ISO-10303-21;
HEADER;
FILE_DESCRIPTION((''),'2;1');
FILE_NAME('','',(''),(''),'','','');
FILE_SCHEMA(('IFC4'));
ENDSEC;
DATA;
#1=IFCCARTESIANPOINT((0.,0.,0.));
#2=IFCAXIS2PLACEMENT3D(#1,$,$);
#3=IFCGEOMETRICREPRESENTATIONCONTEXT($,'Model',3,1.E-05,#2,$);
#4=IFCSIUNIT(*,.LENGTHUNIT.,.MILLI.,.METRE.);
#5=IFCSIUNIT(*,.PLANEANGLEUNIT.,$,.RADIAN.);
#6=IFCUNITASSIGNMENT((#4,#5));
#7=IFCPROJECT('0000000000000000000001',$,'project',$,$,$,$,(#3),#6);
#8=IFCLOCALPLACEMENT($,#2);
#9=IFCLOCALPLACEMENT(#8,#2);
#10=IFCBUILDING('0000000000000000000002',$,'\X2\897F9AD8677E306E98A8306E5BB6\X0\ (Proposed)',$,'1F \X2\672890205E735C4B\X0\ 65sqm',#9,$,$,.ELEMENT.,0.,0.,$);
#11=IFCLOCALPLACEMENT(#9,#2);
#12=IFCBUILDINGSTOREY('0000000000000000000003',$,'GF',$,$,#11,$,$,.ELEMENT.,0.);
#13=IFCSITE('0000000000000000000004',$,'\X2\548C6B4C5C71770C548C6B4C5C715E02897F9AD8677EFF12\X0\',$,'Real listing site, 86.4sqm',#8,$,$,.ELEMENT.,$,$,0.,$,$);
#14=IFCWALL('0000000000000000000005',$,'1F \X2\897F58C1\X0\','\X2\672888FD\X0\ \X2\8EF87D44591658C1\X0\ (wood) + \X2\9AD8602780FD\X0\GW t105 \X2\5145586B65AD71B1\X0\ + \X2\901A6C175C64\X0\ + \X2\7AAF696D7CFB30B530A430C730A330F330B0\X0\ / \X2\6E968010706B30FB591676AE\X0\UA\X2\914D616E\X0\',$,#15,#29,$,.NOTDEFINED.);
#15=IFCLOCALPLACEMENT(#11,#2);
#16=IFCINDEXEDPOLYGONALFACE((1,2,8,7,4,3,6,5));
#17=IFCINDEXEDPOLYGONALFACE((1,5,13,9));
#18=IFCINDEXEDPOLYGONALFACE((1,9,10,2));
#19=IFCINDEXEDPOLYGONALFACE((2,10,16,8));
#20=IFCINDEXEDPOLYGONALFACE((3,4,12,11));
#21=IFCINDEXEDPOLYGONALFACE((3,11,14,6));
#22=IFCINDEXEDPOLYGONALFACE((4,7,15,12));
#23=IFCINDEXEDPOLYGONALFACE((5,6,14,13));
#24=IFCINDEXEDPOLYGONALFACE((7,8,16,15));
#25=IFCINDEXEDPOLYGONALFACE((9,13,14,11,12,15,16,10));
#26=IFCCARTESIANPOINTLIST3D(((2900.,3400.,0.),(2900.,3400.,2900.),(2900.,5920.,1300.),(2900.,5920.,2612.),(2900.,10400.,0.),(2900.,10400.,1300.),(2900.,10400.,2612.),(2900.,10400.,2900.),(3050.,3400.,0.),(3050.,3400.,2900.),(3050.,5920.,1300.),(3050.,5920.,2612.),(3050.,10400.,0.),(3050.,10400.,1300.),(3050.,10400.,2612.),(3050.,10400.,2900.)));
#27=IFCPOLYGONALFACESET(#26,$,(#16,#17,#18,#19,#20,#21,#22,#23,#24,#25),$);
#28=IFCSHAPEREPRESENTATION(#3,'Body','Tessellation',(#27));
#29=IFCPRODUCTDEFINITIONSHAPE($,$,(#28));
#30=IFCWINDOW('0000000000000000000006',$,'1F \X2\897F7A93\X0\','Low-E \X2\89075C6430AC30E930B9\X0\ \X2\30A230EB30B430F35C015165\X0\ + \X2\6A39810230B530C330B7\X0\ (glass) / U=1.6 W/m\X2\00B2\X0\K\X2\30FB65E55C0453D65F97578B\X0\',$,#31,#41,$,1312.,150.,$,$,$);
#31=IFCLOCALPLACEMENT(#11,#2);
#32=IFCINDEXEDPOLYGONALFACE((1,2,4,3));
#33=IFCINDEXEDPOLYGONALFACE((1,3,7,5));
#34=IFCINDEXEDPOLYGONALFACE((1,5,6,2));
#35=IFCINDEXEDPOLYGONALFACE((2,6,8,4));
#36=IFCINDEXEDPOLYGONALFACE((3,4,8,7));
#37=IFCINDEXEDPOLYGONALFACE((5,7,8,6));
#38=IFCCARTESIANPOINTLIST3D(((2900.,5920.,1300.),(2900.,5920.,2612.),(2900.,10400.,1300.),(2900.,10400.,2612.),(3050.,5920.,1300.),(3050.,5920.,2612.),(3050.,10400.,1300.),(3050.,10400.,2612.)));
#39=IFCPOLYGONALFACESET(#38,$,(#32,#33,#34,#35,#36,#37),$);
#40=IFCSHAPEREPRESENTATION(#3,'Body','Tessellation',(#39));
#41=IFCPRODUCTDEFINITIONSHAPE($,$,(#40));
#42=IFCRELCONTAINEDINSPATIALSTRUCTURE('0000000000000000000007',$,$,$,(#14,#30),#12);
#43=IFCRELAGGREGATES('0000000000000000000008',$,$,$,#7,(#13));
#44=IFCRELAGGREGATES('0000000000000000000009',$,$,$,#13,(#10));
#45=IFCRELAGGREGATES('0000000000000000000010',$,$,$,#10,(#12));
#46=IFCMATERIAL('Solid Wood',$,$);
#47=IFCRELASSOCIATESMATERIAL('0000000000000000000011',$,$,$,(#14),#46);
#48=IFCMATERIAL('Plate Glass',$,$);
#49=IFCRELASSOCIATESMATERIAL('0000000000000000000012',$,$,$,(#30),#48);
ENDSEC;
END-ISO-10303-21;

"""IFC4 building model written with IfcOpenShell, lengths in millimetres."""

from ifc_helpers import new_model, si_unit, frame, frame_2d, origin, place, context, project, spatial, rectangle, extrude, material, element, fill, save


model = new_model("IFC4")

# Units and contexts
model_context = context("Model", 3, precision=1e-05, world=origin())
ifc_project = project(units=[si_unit("LENGTHUNIT", "METRE", prefix="MILLI"), si_unit("PLANEANGLEUNIT", "RADIAN")], contexts=[model_context])

# Site, building, storey
site_placement = place(None, origin())
site = spatial("IfcSite", under=ifc_project, at=site_placement, Name="和歌山県和歌山市西高松２", ObjectType="Real listing site, 86.4sqm", CompositionType="ELEMENT", RefElevation=0.0)
building_placement = place(site_placement, origin())
building = spatial("IfcBuilding", under=site, at=building_placement, Name="西高松の風の家 (Proposed)", ObjectType="1F 木造平屋 65sqm", CompositionType="ELEMENT", ElevationOfRefHeight=0.0, ElevationOfTerrain=0.0)
storey_placement = place(building_placement, origin())
storey = spatial("IfcBuildingStorey", under=building, at=storey_placement, Name="GF", CompositionType="ELEMENT", Elevation=0.0)

# Shared definitions
ifc_material_1 = material(Name="Solid Wood")

# Shared definitions
ifc_material_2 = material(Name="Plate Glass")

# Wall, opening, window
wall_1_placement = place(storey_placement, frame((1450.0, 1700.0, 0.0)))
wall_1 = element("IfcWall", 1, at=wall_1_placement, inside=storey, material=ifc_material_1, Name="1F 西壁", Description="木製 軸組外壁 (wood) + 高性能GW t105 充填断熱 + 通気層 + 窯業系サイディング / 準耐火・外皮UA配慮", PredefinedType="NOTDEFINED", context=model_context, shape_type="SweptSolid", body=[
    extrude(rectangle(XDim=150.0, YDim=7000.0, at=frame_2d((75.0, 3500.0))), frame((1450.0, 1700.0, 0.0)), (0.0, 0.0, 1.0), 2900.0),
])
opening_1_placement = place(storey_placement, frame((1450.0, 2960.0, 650.0)))
opening_1 = element("IfcOpeningElement", 2, at=opening_1_placement, cuts=wall_1, PredefinedType="NOTDEFINED", context=model_context, shape_type="SweptSolid", body=[
    extrude(rectangle(XDim=150.0, YDim=4480.0, at=frame_2d((75.0, 2240.0))), frame((1450.0, 2960.0, 650.0)), (0.0, 0.0, 1.0), 1312.0),
])
window_1_placement = place(storey_placement, frame((1450.0, 2960.0, 650.0)))
window_1 = element("IfcWindow", 3, at=window_1_placement, inside=storey, material=ifc_material_2, Name="1F 西窓", Description="Low-E 複層ガラス アルゴン封入 + 樹脂サッシ (glass) / U=1.6 W/m²K・日射取得型", OverallHeight=1312.0, OverallWidth=150.0, context=model_context, shape_type="SweptSolid", body=[
    extrude(rectangle(XDim=150.0, YDim=4480.0, at=frame_2d((75.0, 2240.0))), frame((1450.0, 2960.0, 650.0)), (0.0, 0.0, 1.0), 1312.0),
])
fill(opening_1, window_1)

save(model, "model.ifc")
